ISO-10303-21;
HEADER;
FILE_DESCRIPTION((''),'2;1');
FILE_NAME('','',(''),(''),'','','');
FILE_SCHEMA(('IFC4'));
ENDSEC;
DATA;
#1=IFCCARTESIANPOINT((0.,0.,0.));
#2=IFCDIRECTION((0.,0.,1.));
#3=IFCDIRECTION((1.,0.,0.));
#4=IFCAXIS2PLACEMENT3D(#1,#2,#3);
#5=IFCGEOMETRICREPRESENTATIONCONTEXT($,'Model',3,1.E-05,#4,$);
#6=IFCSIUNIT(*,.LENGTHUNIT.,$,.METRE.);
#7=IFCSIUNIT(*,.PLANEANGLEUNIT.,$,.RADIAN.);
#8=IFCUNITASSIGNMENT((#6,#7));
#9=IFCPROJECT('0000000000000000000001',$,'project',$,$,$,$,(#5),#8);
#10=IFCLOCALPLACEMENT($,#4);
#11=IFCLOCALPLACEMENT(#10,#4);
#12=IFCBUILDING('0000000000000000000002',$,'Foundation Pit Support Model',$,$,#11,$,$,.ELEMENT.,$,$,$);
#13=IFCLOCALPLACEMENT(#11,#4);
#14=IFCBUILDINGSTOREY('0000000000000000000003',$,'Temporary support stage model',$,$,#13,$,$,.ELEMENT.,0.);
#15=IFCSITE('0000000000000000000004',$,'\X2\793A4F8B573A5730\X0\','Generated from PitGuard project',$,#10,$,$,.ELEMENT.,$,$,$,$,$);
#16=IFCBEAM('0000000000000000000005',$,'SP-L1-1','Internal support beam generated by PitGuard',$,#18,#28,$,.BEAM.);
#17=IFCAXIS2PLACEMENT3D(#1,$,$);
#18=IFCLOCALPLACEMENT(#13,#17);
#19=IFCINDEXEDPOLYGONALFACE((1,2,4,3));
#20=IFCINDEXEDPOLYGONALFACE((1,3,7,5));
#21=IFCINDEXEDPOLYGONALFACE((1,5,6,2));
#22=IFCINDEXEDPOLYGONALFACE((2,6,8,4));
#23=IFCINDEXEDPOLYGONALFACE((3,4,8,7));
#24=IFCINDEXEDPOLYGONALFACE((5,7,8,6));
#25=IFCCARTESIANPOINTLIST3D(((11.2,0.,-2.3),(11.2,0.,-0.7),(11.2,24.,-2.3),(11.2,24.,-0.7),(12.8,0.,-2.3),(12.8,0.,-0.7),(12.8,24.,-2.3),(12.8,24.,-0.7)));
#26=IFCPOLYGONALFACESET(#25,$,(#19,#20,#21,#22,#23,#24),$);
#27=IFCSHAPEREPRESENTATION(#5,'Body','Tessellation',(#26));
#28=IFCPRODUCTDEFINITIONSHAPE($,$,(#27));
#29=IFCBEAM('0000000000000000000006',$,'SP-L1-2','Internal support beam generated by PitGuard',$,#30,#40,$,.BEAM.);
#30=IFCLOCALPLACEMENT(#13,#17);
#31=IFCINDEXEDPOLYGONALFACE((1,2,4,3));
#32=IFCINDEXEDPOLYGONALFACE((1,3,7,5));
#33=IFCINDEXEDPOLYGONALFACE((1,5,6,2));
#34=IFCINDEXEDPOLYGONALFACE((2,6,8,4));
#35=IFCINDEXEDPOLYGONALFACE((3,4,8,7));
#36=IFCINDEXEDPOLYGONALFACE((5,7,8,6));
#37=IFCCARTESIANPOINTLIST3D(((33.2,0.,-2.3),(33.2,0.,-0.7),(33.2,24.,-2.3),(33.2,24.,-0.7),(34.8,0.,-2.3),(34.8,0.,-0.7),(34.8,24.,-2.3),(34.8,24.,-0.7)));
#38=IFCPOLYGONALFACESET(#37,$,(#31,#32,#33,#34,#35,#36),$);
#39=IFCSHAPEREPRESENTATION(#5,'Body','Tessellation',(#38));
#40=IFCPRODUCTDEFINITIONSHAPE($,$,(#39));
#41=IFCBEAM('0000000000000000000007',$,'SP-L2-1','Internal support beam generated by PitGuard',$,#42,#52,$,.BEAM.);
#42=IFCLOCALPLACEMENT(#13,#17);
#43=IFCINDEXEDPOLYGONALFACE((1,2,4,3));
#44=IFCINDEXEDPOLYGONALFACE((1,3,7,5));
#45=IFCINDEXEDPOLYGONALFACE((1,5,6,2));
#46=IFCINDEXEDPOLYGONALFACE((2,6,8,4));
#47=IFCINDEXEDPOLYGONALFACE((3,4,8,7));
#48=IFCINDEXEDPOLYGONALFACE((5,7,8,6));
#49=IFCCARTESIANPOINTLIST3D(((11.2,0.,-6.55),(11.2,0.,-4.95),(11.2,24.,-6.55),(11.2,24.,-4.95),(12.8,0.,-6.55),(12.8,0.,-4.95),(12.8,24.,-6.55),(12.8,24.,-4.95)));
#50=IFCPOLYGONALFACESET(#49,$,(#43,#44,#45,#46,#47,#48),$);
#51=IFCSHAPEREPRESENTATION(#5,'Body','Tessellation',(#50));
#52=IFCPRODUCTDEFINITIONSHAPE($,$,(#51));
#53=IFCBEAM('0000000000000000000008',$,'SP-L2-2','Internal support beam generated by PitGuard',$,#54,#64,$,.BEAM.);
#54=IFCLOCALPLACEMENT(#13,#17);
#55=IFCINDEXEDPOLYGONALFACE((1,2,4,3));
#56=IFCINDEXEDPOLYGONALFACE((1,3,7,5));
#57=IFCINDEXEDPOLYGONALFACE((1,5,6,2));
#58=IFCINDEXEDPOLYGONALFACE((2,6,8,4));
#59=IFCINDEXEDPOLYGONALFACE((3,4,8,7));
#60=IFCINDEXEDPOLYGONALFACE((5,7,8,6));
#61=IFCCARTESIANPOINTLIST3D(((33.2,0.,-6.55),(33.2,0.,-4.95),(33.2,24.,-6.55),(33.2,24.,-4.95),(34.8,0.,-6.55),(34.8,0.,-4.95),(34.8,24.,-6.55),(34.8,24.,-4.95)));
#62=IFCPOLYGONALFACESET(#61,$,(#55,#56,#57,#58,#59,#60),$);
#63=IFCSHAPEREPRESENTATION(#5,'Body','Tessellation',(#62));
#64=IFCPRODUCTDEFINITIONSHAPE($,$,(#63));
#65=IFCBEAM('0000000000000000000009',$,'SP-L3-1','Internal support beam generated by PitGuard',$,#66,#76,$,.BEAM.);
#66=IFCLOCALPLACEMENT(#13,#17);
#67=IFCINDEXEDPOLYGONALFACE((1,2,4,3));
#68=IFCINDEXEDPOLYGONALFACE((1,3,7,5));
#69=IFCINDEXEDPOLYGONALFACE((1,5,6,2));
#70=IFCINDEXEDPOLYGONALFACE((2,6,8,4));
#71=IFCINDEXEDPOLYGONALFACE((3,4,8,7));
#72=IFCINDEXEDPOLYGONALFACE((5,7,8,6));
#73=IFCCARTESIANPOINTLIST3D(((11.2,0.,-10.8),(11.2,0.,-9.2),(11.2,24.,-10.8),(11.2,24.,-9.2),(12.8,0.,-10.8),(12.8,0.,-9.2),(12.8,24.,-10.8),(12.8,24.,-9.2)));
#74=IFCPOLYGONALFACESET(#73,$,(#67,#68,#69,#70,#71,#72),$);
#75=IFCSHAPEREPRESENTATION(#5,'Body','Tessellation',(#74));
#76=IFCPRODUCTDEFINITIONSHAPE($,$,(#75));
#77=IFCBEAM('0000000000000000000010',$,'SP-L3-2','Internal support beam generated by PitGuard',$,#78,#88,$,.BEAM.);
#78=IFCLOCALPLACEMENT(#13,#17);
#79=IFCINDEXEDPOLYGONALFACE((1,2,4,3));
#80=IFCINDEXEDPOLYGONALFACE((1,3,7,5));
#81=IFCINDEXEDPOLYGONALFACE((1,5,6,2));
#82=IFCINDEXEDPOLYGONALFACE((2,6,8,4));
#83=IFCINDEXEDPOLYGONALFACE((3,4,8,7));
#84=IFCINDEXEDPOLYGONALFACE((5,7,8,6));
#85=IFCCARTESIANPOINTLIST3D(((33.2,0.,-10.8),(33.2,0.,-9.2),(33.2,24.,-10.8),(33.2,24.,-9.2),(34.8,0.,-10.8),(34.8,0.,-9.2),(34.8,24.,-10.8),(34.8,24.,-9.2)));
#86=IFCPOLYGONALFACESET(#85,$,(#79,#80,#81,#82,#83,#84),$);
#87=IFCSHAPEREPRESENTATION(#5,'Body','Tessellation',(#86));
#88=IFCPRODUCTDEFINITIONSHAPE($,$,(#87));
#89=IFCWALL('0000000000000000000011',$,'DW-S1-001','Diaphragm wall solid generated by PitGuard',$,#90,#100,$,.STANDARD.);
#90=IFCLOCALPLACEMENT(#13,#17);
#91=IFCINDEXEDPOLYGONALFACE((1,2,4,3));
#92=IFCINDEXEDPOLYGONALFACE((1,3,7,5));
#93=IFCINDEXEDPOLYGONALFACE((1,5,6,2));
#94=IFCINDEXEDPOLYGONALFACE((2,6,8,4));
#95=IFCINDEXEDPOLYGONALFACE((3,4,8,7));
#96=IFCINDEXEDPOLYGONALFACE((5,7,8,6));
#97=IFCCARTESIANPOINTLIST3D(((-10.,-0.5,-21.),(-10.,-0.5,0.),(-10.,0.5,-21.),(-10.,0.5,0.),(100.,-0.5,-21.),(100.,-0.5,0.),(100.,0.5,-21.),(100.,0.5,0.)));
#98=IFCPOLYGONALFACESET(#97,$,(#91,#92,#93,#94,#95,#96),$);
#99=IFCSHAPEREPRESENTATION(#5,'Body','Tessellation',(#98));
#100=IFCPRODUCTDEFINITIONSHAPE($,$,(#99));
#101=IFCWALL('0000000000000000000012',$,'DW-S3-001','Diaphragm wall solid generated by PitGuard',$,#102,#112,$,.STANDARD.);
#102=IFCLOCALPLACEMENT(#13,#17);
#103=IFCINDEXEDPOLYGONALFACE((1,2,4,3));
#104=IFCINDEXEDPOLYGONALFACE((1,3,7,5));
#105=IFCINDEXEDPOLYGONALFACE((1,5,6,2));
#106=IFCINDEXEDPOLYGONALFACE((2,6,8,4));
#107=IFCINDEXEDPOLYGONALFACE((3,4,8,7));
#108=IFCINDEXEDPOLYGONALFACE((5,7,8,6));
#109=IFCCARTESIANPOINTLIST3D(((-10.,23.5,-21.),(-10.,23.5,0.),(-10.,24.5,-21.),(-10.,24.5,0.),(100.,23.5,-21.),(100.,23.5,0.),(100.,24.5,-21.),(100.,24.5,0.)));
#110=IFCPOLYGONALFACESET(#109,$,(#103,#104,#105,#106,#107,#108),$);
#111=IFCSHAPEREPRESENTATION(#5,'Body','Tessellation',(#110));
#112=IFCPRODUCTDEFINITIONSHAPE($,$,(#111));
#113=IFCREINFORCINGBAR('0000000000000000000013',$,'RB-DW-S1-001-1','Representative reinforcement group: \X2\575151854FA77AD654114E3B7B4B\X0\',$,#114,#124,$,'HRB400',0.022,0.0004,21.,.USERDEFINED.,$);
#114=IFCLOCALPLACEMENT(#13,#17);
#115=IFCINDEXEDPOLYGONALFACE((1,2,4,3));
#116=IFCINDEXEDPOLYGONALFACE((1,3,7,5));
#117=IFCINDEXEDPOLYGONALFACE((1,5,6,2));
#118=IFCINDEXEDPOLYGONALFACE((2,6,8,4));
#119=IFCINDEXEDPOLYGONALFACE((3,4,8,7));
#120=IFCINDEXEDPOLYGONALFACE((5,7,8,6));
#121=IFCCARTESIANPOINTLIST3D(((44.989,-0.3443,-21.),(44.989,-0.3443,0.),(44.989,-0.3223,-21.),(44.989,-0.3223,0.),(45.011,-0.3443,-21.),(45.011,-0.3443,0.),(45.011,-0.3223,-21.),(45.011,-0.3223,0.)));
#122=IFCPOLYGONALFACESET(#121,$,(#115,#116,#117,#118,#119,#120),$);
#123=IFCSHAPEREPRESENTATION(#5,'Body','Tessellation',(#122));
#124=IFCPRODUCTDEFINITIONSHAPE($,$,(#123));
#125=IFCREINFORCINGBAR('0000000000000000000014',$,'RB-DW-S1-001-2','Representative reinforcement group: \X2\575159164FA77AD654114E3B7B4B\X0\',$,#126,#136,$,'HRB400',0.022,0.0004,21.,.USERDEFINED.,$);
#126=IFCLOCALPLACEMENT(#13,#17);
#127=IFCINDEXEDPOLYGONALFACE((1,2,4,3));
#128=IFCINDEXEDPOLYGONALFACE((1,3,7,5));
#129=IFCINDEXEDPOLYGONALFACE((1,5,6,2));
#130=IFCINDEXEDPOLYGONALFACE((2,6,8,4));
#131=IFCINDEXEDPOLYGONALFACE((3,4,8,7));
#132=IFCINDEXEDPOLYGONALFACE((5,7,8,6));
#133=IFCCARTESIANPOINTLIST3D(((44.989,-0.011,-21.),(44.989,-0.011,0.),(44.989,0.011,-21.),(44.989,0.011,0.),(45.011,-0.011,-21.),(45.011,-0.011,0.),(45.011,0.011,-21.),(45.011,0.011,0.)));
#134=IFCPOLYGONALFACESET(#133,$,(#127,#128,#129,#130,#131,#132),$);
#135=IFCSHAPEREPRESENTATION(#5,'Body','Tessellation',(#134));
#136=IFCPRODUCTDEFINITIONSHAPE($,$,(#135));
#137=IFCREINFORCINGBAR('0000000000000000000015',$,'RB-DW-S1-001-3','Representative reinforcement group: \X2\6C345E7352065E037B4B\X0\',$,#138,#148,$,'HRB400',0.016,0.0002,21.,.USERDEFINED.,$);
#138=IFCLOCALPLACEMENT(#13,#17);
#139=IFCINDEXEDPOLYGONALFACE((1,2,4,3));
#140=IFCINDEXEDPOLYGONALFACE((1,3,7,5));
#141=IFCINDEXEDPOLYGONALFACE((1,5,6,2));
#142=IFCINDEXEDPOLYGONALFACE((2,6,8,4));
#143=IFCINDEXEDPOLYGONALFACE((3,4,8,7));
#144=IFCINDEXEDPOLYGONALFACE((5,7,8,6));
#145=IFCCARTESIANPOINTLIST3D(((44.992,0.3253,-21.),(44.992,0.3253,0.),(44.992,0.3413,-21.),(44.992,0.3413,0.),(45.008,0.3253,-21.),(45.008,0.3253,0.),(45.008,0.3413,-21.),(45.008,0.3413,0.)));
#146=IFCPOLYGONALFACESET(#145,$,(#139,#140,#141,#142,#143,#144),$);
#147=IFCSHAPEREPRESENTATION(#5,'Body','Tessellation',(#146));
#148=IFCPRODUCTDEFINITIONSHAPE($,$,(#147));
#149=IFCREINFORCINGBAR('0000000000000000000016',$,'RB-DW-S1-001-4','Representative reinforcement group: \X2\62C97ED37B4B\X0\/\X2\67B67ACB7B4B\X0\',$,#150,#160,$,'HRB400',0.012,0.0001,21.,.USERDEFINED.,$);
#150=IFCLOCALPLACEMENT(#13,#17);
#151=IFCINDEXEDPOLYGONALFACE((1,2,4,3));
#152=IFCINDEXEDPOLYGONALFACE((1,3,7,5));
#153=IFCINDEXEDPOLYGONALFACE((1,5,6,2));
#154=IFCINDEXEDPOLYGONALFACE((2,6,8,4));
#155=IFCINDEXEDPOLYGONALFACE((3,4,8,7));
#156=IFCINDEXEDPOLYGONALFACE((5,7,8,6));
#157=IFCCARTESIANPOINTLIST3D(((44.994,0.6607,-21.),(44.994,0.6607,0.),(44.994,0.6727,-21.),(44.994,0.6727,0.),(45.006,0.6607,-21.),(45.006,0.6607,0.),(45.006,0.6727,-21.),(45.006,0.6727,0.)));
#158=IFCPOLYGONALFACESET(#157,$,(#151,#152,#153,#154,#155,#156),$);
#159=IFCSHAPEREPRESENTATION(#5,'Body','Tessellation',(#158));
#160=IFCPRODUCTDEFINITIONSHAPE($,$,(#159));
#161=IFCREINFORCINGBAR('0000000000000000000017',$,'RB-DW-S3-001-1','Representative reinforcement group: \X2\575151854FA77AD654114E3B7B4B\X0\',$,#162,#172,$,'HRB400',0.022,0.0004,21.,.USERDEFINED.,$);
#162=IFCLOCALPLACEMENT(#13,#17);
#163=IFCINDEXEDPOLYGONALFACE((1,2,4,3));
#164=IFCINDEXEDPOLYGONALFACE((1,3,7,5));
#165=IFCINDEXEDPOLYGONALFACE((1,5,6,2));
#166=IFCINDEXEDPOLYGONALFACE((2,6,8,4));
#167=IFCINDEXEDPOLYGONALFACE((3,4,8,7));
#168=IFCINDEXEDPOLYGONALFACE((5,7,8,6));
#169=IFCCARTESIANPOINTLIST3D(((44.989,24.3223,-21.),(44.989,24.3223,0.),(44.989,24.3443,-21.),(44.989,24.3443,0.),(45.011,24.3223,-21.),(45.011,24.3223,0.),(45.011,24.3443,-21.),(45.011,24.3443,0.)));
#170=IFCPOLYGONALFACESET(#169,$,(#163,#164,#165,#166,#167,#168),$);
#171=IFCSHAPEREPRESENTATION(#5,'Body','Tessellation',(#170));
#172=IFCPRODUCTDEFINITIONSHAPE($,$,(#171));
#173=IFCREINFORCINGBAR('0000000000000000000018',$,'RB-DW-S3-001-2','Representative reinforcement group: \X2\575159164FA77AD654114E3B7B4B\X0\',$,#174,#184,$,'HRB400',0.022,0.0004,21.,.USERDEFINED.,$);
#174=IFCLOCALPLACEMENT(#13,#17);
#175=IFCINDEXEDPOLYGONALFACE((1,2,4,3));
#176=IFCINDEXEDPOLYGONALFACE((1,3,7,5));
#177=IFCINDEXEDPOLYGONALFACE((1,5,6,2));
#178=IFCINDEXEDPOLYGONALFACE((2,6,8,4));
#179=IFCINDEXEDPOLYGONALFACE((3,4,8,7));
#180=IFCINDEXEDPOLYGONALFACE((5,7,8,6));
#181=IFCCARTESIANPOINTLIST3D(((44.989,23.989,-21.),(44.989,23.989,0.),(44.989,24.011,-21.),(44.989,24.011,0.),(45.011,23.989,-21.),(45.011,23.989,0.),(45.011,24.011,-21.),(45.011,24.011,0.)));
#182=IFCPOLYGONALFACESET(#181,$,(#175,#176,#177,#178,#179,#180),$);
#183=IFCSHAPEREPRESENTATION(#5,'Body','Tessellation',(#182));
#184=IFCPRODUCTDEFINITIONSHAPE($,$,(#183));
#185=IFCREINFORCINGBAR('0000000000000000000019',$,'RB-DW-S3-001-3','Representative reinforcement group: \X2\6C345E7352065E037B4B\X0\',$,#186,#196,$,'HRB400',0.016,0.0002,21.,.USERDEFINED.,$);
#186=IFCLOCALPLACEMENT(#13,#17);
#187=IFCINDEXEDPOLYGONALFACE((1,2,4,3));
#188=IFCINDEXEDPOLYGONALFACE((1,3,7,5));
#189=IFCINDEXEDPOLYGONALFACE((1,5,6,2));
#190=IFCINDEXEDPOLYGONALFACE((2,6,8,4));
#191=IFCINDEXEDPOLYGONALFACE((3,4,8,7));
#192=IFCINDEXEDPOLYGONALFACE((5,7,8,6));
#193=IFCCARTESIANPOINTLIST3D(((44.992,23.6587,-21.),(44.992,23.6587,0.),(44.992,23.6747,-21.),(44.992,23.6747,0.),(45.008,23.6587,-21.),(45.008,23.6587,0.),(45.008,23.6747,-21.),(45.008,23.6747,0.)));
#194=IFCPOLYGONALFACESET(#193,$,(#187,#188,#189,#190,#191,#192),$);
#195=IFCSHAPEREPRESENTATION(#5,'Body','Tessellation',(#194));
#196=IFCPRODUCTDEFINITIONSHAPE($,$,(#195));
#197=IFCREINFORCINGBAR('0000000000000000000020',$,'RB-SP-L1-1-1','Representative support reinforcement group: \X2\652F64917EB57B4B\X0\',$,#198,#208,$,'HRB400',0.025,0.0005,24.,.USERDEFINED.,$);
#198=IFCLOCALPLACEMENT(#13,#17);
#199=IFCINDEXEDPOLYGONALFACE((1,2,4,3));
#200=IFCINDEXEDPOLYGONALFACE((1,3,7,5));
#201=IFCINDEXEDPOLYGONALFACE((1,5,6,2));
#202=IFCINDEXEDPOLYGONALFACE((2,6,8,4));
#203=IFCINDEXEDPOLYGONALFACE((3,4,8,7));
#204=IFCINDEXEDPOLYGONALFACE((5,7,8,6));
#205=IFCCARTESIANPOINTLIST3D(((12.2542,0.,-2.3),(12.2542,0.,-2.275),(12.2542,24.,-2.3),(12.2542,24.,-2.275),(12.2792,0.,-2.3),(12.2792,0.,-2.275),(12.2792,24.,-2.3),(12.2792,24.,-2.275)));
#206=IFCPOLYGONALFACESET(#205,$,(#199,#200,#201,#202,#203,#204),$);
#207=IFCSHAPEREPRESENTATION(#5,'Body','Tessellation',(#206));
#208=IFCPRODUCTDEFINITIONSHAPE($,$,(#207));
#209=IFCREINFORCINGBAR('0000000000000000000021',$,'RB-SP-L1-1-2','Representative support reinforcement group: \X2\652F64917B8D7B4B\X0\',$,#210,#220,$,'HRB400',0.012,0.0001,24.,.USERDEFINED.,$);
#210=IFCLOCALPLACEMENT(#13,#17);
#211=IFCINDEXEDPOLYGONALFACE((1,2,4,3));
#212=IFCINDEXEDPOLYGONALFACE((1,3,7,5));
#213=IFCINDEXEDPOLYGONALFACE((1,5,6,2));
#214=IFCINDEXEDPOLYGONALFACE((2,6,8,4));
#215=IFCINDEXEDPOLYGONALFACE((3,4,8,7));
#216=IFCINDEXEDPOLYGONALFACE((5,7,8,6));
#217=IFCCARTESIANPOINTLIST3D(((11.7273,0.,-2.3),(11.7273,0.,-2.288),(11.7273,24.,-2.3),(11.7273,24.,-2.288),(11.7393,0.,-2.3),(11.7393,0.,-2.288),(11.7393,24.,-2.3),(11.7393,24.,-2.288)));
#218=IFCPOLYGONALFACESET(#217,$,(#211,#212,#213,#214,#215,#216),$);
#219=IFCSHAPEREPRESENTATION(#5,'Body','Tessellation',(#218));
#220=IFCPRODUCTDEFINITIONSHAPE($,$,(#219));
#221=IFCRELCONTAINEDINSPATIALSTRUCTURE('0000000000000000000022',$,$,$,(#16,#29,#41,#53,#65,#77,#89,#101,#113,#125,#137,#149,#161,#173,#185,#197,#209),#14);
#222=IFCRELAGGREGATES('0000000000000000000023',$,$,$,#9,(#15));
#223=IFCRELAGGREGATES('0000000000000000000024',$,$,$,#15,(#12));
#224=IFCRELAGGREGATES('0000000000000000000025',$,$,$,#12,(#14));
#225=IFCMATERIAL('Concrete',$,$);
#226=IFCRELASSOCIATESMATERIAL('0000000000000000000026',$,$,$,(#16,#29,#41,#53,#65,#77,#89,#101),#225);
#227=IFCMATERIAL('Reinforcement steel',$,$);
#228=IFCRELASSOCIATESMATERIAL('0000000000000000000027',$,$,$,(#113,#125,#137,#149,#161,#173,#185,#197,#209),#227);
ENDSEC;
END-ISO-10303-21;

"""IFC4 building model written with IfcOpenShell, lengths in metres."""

from ifc_helpers import new_model, si_unit, frame, origin_with_axes, origin_2d, place, context, project, spatial, rectangle, extrude, material, element, save


model = new_model("IFC4")

# Units and contexts
model_context = context("Model", 3, precision=1e-05, world=origin_with_axes())
ifc_project = project(units=[si_unit("LENGTHUNIT", "METRE"), si_unit("PLANEANGLEUNIT", "RADIAN")], contexts=[model_context])

# Site, building, storey
site_placement = place(None, origin_with_axes())
site = spatial("IfcSite", under=ifc_project, at=site_placement, Name="示例场地", Description="Generated from PitGuard project", CompositionType="ELEMENT")
building_placement = place(site_placement, origin_with_axes())
building = spatial("IfcBuilding", under=site, at=building_placement, Name="Foundation Pit Support Model", CompositionType="ELEMENT")
storey_placement = place(building_placement, origin_with_axes())
storey = spatial("IfcBuildingStorey", under=building, at=storey_placement, Name="Temporary support stage model", CompositionType="ELEMENT", Elevation=0.0)

# Beams
ifc_material_1 = material(Name="Concrete")
for number, where, z_axis, x_axis, name in (
    (1, (12.0, 12.0, -2.3), (0.0, 0.0, 1.0), (0.0, 1.0, 0.0), "SP-L1-1"),
    (2, (34.0, 12.0, -2.3), (0.0, 0.0, 1.0), (0.0, 1.0, 0.0), "SP-L1-2"),
    (3, (12.0, 12.0, -6.55), (0.0, 0.0, 1.0), (0.0, 1.0, 0.0), "SP-L2-1"),
    (4, (34.0, 12.0, -6.55), (0.0, 0.0, 1.0), (0.0, 1.0, 0.0), "SP-L2-2"),
    (5, (12.0, 12.0, -10.8), (0.0, 0.0, 1.0), (0.0, 1.0, 0.0), "SP-L3-1"),
    (6, (34.0, 12.0, -10.8), (0.0, 0.0, 1.0), (0.0, 1.0, 0.0), "SP-L3-2"),
):
    element("IfcBeam", number, at=place(storey_placement, frame(where, z_axis=z_axis, x_axis=x_axis)), inside=storey, material=ifc_material_1, Name=name, Description="Internal support beam generated by PitGuard", PredefinedType="BEAM", context=model_context, shape_type="SweptSolid", body=[
        extrude(rectangle(XDim=24.0, YDim=1.6, at=origin_2d()), origin_with_axes(), (0.0, 0.0, 1.0), 1.6),
    ])

# Walls
for number, where, z_axis, x_axis, name in (
    (7, (45.0, 0.0, -21.0), (0.0, 0.0, 1.0), (1.0, 0.0, 0.0), "DW-S1-001"),
    (8, (45.0, 24.0, -21.0), (0.0, 0.0, 1.0), (-1.0, 0.0, 0.0), "DW-S3-001"),
):
    element("IfcWall", number, at=place(storey_placement, frame(where, z_axis=z_axis, x_axis=x_axis)), inside=storey, material=ifc_material_1, Name=name, Description="Diaphragm wall solid generated by PitGuard", PredefinedType="STANDARD", context=model_context, shape_type="SweptSolid", body=[
        extrude(rectangle(XDim=110.0, YDim=1.0, at=origin_2d()), origin_with_axes(), (0.0, 0.0, 1.0), 21.0),
    ])

# Reinforcing bars
ifc_material_2 = material(Name="Reinforcement steel")
for number, where, z_axis, x_axis, name, description in (
    (9, (45.0, -0.3333, -21.0), (0.0, 0.0, 1.0), (1.0, 0.0, 0.0), "RB-DW-S1-001-1", "Representative reinforcement group: 坑内侧竖向主筋"),
    (10, (45.0, 0.0, -21.0), (0.0, 0.0, 1.0), (1.0, 0.0, 0.0), "RB-DW-S1-001-2", "Representative reinforcement group: 坑外侧竖向主筋"),
):
    element("IfcReinforcingBar", number, at=place(storey_placement, frame(where, z_axis=z_axis, x_axis=x_axis)), inside=storey, material=ifc_material_2, Name=name, Description=description, SteelGrade="HRB400", BarLength=21.0, CrossSectionArea=0.0004, NominalDiameter=0.022, PredefinedType="USERDEFINED", context=model_context, shape_type="SweptSolid", body=[
        extrude(rectangle(XDim=0.022, YDim=0.022, at=origin_2d()), origin_with_axes(), (0.0, 0.0, 1.0), 21.0),
    ])
reinforcing_bar_1_placement = place(storey_placement, frame((45.0, 0.3333, -21.0), z_axis=(0.0, 0.0, 1.0), x_axis=(1.0, 0.0, 0.0)))
element("IfcReinforcingBar", 11, at=reinforcing_bar_1_placement, inside=storey, material=ifc_material_2, Name="RB-DW-S1-001-3", Description="Representative reinforcement group: 水平分布筋", SteelGrade="HRB400", BarLength=21.0, CrossSectionArea=0.0002, NominalDiameter=0.016, PredefinedType="USERDEFINED", context=model_context, shape_type="SweptSolid", body=[
    extrude(rectangle(XDim=0.016, YDim=0.016, at=origin_2d()), origin_with_axes(), (0.0, 0.0, 1.0), 21.0),
])
reinforcing_bar_2_placement = place(storey_placement, frame((45.0, 0.6667, -21.0), z_axis=(0.0, 0.0, 1.0), x_axis=(1.0, 0.0, 0.0)))
element("IfcReinforcingBar", 12, at=reinforcing_bar_2_placement, inside=storey, material=ifc_material_2, Name="RB-DW-S1-001-4", Description="Representative reinforcement group: 拉结筋/架立筋", SteelGrade="HRB400", BarLength=21.0, CrossSectionArea=0.0001, NominalDiameter=0.012, PredefinedType="USERDEFINED", context=model_context, shape_type="SweptSolid", body=[
    extrude(rectangle(XDim=0.012, YDim=0.012, at=origin_2d()), origin_with_axes(), (0.0, 0.0, 1.0), 21.0),
])
for number, where, z_axis, x_axis, name, description in (
    (13, (45.0, 24.3333, -21.0), (0.0, 0.0, 1.0), (1.0, 0.0, 0.0), "RB-DW-S3-001-1", "Representative reinforcement group: 坑内侧竖向主筋"),
    (14, (45.0, 24.0, -21.0), (0.0, 0.0, 1.0), (1.0, 0.0, 0.0), "RB-DW-S3-001-2", "Representative reinforcement group: 坑外侧竖向主筋"),
):
    element("IfcReinforcingBar", number, at=place(storey_placement, frame(where, z_axis=z_axis, x_axis=x_axis)), inside=storey, material=ifc_material_2, Name=name, Description=description, SteelGrade="HRB400", BarLength=21.0, CrossSectionArea=0.0004, NominalDiameter=0.022, PredefinedType="USERDEFINED", context=model_context, shape_type="SweptSolid", body=[
        extrude(rectangle(XDim=0.022, YDim=0.022, at=origin_2d()), origin_with_axes(), (0.0, 0.0, 1.0), 21.0),
    ])
reinforcing_bar_3_placement = place(storey_placement, frame((45.0, 23.6667, -21.0), z_axis=(0.0, 0.0, 1.0), x_axis=(1.0, 0.0, 0.0)))
element("IfcReinforcingBar", 15, at=reinforcing_bar_3_placement, inside=storey, material=ifc_material_2, Name="RB-DW-S3-001-3", Description="Representative reinforcement group: 水平分布筋", SteelGrade="HRB400", BarLength=21.0, CrossSectionArea=0.0002, NominalDiameter=0.016, PredefinedType="USERDEFINED", context=model_context, shape_type="SweptSolid", body=[
    extrude(rectangle(XDim=0.016, YDim=0.016, at=origin_2d()), origin_with_axes(), (0.0, 0.0, 1.0), 21.0),
])
reinforcing_bar_4_placement = place(storey_placement, frame((12.2667, 12.0, -2.3), z_axis=(0.0, 0.0, 1.0), x_axis=(0.0, 1.0, 0.0)))
element("IfcReinforcingBar", 16, at=reinforcing_bar_4_placement, inside=storey, material=ifc_material_2, Name="RB-SP-L1-1-1", Description="Representative support reinforcement group: 支撑纵筋", SteelGrade="HRB400", BarLength=24.0, CrossSectionArea=0.0005, NominalDiameter=0.025, PredefinedType="USERDEFINED", context=model_context, shape_type="SweptSolid", body=[
    extrude(rectangle(XDim=24.0, YDim=0.025, at=origin_2d()), origin_with_axes(), (0.0, 0.0, 1.0), 0.025),
])
reinforcing_bar_5_placement = place(storey_placement, frame((11.7333, 12.0, -2.3), z_axis=(0.0, 0.0, 1.0), x_axis=(0.0, 1.0, 0.0)))
element("IfcReinforcingBar", 17, at=reinforcing_bar_5_placement, inside=storey, material=ifc_material_2, Name="RB-SP-L1-1-2", Description="Representative support reinforcement group: 支撑箍筋", SteelGrade="HRB400", BarLength=24.0, CrossSectionArea=0.0001, NominalDiameter=0.012, PredefinedType="USERDEFINED", context=model_context, shape_type="SweptSolid", body=[
    extrude(rectangle(XDim=24.0, YDim=0.012, at=origin_2d()), origin_with_axes(), (0.0, 0.0, 1.0), 0.012),
])

save(model, "model.ifc")
